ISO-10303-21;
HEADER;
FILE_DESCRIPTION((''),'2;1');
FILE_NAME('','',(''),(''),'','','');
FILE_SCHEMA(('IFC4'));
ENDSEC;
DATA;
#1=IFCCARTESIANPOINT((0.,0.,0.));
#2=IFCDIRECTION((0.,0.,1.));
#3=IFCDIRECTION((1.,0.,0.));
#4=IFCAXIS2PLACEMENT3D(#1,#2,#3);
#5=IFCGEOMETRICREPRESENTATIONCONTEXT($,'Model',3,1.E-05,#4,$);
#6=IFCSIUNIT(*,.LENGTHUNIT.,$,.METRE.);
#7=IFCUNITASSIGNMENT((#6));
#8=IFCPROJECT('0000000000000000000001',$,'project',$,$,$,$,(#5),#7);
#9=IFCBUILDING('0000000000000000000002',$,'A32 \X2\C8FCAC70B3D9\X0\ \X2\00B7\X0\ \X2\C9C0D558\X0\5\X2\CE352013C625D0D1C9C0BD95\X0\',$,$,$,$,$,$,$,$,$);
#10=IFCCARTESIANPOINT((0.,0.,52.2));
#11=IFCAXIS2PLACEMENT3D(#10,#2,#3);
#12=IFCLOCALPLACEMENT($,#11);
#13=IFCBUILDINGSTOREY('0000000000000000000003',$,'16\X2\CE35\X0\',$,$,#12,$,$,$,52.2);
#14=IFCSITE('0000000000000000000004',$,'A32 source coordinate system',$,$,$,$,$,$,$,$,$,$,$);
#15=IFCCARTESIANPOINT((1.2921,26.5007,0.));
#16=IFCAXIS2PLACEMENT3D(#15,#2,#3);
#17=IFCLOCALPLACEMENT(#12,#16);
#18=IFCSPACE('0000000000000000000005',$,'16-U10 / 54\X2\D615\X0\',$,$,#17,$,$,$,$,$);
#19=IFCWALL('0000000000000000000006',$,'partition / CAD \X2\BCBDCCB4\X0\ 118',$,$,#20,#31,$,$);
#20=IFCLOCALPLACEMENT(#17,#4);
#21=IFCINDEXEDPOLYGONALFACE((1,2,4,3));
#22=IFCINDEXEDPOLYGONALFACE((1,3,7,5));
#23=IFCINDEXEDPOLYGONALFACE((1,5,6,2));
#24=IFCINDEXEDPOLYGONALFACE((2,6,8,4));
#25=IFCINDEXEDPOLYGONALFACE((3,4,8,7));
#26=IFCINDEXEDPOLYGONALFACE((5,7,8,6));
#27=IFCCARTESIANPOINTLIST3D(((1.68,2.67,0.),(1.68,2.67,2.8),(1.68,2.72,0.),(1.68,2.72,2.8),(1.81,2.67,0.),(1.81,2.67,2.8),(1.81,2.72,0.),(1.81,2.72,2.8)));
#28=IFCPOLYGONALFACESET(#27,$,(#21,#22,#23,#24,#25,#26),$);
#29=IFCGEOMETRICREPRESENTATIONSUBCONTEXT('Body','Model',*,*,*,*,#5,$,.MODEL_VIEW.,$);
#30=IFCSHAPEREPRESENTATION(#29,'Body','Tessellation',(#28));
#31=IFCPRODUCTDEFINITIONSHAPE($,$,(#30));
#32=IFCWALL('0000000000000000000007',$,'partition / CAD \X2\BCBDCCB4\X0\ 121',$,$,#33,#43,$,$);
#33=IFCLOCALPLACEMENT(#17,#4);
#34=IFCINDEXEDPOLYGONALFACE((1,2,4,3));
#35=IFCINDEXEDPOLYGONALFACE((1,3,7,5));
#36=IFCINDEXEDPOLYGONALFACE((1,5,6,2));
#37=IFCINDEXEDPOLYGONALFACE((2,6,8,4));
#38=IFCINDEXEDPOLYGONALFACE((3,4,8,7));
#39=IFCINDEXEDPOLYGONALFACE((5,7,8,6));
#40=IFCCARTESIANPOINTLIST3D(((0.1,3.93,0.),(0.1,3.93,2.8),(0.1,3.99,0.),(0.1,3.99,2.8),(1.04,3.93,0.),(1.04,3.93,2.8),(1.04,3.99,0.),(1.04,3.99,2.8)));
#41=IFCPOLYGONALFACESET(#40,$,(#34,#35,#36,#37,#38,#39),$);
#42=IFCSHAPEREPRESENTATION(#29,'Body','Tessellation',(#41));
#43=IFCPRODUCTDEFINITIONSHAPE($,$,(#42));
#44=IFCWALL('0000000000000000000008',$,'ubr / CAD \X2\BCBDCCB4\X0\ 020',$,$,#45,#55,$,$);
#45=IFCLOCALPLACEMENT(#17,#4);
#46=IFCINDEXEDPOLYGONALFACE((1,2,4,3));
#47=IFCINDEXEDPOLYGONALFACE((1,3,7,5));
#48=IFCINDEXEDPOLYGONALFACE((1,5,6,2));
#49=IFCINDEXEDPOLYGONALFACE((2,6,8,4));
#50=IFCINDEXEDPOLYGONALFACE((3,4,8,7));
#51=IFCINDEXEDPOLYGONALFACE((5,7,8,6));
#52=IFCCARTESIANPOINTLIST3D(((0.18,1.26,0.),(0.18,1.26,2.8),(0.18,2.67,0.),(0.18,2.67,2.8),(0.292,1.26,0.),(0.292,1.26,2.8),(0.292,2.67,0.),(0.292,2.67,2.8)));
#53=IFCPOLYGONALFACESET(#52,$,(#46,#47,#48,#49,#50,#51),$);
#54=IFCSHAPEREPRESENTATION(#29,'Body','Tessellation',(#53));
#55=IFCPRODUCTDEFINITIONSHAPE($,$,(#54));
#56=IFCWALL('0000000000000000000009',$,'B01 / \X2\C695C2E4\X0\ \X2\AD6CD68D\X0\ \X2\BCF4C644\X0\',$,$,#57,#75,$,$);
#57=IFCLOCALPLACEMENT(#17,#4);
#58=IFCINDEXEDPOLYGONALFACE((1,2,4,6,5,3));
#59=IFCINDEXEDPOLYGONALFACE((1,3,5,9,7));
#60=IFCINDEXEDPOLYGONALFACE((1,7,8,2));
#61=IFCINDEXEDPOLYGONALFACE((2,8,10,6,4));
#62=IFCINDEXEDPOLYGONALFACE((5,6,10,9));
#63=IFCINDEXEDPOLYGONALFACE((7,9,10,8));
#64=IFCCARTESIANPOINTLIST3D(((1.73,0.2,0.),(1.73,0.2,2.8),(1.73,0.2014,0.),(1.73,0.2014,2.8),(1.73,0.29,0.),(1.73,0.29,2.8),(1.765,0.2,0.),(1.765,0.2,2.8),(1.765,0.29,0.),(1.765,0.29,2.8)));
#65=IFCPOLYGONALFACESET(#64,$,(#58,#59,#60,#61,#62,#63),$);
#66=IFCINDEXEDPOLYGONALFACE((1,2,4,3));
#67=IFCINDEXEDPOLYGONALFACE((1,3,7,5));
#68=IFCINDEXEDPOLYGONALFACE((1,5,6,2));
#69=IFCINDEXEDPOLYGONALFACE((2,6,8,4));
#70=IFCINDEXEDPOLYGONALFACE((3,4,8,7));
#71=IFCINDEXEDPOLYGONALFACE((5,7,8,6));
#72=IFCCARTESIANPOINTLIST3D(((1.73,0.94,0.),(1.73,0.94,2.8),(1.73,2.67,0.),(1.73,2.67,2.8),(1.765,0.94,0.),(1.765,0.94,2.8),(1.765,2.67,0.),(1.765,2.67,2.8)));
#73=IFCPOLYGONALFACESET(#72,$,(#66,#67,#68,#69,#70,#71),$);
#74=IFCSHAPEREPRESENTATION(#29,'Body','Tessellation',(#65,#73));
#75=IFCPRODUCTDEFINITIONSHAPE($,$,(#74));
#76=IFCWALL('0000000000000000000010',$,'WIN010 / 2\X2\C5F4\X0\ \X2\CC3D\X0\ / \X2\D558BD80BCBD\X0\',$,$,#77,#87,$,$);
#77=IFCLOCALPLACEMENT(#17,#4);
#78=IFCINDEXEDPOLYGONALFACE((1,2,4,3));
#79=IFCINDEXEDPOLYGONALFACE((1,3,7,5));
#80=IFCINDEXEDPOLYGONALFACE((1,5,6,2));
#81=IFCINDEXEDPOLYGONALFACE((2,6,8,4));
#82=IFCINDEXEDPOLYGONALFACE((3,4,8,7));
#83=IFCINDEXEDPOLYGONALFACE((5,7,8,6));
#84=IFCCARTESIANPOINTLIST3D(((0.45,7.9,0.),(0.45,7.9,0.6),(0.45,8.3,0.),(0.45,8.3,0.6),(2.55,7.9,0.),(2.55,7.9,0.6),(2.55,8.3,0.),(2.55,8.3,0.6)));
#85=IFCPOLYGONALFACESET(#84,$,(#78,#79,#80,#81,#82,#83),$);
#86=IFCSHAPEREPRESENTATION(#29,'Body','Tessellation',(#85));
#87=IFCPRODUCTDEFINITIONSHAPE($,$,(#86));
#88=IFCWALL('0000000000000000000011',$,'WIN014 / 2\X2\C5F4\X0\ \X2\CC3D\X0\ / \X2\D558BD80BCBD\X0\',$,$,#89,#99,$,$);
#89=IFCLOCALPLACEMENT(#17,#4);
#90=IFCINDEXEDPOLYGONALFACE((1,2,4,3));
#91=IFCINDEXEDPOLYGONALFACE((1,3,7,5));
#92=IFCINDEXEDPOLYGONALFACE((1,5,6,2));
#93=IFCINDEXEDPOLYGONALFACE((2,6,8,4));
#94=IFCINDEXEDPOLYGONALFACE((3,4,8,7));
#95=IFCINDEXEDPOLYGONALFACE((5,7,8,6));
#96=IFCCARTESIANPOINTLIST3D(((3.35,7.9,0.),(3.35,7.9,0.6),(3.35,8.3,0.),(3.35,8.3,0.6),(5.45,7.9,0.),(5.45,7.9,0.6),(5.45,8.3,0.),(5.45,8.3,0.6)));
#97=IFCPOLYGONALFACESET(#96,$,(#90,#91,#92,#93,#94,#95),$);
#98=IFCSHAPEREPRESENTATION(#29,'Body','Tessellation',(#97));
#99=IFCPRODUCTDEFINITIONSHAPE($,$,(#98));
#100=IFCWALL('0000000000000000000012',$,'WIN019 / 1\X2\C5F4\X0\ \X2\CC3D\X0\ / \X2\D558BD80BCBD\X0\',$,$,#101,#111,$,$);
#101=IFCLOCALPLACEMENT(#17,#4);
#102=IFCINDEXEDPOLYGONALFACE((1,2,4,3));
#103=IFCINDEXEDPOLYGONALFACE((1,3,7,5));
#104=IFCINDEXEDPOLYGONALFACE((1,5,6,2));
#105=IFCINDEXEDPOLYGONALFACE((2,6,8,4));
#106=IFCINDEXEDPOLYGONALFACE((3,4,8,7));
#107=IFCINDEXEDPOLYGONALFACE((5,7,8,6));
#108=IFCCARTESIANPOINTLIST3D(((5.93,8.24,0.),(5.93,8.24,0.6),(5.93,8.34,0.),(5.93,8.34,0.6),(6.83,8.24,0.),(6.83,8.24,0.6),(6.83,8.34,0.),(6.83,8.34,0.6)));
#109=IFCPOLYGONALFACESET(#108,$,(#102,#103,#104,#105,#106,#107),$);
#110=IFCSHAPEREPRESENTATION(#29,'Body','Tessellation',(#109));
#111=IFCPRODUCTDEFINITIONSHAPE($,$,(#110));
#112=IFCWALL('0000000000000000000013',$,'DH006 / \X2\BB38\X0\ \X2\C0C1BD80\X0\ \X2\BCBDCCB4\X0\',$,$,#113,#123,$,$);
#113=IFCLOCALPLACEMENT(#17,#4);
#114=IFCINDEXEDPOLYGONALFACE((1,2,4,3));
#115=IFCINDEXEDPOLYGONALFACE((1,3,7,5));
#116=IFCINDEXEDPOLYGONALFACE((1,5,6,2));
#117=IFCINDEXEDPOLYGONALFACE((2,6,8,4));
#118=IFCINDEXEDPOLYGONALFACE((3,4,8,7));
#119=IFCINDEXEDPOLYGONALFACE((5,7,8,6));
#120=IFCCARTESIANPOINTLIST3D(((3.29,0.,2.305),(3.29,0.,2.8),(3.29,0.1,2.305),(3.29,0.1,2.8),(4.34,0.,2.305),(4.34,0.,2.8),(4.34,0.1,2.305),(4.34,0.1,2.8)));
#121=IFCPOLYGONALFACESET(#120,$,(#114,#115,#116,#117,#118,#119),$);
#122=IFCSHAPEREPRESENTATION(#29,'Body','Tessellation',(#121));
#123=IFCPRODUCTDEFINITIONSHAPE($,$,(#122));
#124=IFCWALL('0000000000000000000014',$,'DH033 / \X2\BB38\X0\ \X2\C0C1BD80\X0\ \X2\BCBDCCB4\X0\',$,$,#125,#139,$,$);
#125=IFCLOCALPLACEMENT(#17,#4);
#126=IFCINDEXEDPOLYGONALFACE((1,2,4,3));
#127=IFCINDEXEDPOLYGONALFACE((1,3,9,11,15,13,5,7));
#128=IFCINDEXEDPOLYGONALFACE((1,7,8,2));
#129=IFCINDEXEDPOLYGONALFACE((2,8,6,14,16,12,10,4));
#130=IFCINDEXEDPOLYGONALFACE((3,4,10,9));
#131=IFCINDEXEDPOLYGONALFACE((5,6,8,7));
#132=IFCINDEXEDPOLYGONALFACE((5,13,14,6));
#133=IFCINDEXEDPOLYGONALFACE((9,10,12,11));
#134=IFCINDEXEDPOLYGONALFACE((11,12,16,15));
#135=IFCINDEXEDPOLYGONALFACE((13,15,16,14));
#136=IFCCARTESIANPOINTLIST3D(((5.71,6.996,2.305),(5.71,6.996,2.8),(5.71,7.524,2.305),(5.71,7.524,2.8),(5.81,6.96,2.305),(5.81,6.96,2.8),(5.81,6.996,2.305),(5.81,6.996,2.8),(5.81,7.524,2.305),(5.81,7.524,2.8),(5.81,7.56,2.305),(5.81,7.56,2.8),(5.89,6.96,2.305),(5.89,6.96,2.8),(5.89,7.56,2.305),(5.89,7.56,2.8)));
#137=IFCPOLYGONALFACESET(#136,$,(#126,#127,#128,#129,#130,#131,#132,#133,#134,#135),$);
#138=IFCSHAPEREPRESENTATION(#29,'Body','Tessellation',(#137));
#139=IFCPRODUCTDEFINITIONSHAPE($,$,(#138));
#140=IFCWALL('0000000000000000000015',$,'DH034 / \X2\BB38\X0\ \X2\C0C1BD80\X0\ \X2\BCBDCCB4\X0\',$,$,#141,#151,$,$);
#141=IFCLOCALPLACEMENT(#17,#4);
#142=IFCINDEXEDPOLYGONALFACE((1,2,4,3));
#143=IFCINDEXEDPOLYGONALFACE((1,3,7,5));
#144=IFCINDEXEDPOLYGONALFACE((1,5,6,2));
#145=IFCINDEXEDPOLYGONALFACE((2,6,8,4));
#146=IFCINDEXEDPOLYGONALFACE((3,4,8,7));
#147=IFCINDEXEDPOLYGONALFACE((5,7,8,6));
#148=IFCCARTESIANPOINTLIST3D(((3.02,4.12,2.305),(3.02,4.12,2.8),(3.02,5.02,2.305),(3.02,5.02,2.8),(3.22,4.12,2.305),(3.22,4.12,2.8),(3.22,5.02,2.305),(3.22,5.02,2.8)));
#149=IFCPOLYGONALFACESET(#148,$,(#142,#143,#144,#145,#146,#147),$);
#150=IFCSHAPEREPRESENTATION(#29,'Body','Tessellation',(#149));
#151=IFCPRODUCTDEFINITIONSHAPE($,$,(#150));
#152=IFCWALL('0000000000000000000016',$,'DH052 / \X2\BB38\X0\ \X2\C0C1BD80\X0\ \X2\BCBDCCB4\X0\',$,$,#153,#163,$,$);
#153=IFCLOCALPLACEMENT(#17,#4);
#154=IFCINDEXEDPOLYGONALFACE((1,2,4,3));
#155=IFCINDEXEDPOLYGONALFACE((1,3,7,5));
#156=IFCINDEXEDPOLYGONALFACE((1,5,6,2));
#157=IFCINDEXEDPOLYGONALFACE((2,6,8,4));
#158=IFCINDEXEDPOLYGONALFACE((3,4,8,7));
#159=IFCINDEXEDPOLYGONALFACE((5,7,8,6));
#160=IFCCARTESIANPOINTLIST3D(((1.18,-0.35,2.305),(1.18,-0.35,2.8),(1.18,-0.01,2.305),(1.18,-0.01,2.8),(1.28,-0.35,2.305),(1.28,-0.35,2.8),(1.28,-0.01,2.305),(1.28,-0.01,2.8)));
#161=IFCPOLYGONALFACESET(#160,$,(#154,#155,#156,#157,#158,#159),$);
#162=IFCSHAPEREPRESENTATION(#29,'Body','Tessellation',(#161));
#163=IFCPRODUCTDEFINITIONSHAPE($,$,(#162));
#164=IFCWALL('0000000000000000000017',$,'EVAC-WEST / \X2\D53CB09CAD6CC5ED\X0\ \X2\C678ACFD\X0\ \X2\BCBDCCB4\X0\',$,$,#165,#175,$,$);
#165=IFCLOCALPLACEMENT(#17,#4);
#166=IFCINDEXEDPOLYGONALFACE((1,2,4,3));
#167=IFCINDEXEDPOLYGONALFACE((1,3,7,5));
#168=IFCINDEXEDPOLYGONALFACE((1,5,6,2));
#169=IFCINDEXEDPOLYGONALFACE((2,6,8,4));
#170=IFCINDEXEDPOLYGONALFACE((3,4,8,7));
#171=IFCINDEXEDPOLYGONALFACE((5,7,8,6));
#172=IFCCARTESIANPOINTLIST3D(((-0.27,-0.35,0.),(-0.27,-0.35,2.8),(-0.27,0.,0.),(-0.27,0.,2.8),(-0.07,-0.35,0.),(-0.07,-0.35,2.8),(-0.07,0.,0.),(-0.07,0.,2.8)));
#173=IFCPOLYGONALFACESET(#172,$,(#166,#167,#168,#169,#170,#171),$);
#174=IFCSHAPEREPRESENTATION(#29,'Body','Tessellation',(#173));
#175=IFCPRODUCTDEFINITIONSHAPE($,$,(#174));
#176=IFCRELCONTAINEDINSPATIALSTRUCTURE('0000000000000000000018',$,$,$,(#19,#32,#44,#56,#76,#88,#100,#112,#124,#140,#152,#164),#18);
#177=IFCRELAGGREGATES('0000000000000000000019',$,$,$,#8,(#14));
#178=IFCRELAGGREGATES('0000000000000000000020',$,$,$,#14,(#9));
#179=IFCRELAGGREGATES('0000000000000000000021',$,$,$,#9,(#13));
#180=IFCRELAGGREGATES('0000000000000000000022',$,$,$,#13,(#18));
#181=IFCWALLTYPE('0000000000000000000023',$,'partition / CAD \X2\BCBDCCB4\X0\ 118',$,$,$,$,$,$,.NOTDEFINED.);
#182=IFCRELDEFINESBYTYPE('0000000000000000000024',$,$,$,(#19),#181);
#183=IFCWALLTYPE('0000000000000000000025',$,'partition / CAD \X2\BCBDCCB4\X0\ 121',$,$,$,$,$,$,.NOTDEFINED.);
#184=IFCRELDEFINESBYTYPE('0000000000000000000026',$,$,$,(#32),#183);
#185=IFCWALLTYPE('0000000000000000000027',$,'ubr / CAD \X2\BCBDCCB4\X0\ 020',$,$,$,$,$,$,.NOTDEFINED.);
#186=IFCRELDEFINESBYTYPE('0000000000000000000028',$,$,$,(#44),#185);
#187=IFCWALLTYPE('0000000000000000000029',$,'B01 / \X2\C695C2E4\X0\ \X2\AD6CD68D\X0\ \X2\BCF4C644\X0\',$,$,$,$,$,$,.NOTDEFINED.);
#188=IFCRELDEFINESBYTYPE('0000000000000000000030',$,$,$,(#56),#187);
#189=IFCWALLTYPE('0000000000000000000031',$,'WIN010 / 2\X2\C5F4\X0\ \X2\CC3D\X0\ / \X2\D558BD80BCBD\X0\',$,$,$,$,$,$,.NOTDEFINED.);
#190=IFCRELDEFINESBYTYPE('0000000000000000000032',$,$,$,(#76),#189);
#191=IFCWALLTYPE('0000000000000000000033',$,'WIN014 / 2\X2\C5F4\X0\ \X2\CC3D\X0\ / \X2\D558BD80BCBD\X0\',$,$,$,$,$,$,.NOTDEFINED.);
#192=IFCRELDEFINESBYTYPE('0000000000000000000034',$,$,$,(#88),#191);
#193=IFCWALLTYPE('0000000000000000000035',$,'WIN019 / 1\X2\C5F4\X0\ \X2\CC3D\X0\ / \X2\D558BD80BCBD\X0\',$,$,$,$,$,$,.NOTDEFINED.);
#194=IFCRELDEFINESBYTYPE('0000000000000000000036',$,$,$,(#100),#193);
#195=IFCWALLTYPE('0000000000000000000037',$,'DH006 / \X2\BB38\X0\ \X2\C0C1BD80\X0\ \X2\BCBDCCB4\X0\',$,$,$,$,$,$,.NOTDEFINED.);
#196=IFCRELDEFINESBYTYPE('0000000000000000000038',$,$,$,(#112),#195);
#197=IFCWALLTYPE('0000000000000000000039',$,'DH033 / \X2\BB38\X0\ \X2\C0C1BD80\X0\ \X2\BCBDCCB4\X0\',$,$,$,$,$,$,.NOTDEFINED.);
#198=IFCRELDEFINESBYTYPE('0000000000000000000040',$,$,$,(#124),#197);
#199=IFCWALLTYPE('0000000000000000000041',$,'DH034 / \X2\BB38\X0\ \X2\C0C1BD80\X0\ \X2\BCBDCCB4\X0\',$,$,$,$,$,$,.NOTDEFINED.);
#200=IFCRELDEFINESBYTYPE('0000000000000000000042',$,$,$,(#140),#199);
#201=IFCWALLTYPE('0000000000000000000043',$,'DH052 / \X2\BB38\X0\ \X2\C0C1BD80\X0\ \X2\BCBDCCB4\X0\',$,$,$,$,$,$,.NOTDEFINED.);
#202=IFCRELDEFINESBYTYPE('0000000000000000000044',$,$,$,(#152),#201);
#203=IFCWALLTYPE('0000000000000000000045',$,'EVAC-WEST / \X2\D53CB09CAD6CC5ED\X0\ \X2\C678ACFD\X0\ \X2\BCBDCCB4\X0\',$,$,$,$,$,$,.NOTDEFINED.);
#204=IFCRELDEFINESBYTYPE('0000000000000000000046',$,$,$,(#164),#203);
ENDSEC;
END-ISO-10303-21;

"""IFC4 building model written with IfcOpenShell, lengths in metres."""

from ifc_helpers import new_model, si_unit, frame, origin, origin_with_axes, place, context, subcontext, project, spatial, polyline, outline, extrude, source, transform, mapped, type_object, type_shapes, element, save


model = new_model("IFC4")

# Units and contexts
model_context = context("Model", 3, precision=1e-05, world=origin_with_axes())
body_context = subcontext(model_context, "Body", "Model", "MODEL_VIEW")
ifc_project = project(units=[si_unit("LENGTHUNIT", "METRE")], contexts=[model_context])

# Site, building, storey, space
site = spatial("IfcSite", under=ifc_project, Name="A32 source coordinate system")
building = spatial("IfcBuilding", under=site, Name="A32 주거동 · 지하5층–옥탑지붕")
storey_placement = place(None, frame((0.0, 0.0, 52.2), z_axis=(0.0, 0.0, 1.0), x_axis=(1.0, 0.0, 0.0)))
storey = spatial("IfcBuildingStorey", under=building, at=storey_placement, Name="16층", Elevation=52.2)
space_placement = place(storey_placement, frame((1.2921, 26.5007, 0.0), z_axis=(0.0, 0.0, 1.0), x_axis=(1.0, 0.0, 0.0)))
space = spatial("IfcSpace", under=storey, at=space_placement, Name="16-U10 / 54형")

# Walls
wall_type_1 = type_object("IfcWallType", Name="partition / CAD 벽체 118", PredefinedType="NOTDEFINED")
shared_shape_1 = source(origin(), body_context, "Body", "SweptSolid", [
    extrude(outline(polyline([(1.81, 2.67), (1.68, 2.67), (1.68, 2.72), (1.81, 2.72), (1.81, 2.67)])), origin(), (0.0, 0.0, 1.0), 2.8),
])
type_shapes(wall_type_1, [shared_shape_1])
wall_1_placement = place(space_placement, origin_with_axes())
element("IfcWall", 1, at=wall_1_placement, inside=space, type_object=wall_type_1, Name="partition / CAD 벽체 118", context=body_context, shape_type="MappedRepresentation", body=[
    mapped(shared_shape_1, transform((0.0, 0.0, 0.0), scale=1.0)),
])
wall_type_2 = type_object("IfcWallType", Name="partition / CAD 벽체 121", PredefinedType="NOTDEFINED")
shared_shape_2 = source(origin(), body_context, "Body", "SweptSolid", [
    extrude(outline(polyline([(0.1, 3.99), (1.04, 3.99), (1.04, 3.93), (0.1, 3.93), (0.1, 3.99)])), origin(), (0.0, 0.0, 1.0), 2.8),
])
type_shapes(wall_type_2, [shared_shape_2])
wall_2_placement = place(space_placement, origin_with_axes())
element("IfcWall", 2, at=wall_2_placement, inside=space, type_object=wall_type_2, Name="partition / CAD 벽체 121", context=body_context, shape_type="MappedRepresentation", body=[
    mapped(shared_shape_2, transform((0.0, 0.0, 0.0), scale=1.0)),
])
wall_type_3 = type_object("IfcWallType", Name="ubr / CAD 벽체 020", PredefinedType="NOTDEFINED")
shared_shape_3 = source(origin(), body_context, "Body", "SweptSolid", [
    extrude(outline(polyline([(0.18, 1.26), (0.18, 2.67), (0.292, 2.67), (0.292, 1.26), (0.18, 1.26)])), origin(), (0.0, 0.0, 1.0), 2.8),
])
type_shapes(wall_type_3, [shared_shape_3])
wall_3_placement = place(space_placement, origin_with_axes())
element("IfcWall", 3, at=wall_3_placement, inside=space, type_object=wall_type_3, Name="ubr / CAD 벽체 020", context=body_context, shape_type="MappedRepresentation", body=[
    mapped(shared_shape_3, transform((0.0, 0.0, 0.0), scale=1.0)),
])
wall_type_4 = type_object("IfcWallType", Name="B01 / 욕실 구획 보완", PredefinedType="NOTDEFINED")
shared_shape_4 = source(origin(), body_context, "Body", "SweptSolid", [
    extrude(outline(polyline([(1.765, 0.2), (1.73, 0.2), (1.73, 0.2014), (1.73, 0.29), (1.765, 0.29), (1.765, 0.2)])), origin(), (0.0, 0.0, 1.0), 2.8),
    extrude(outline(polyline([(1.765, 2.67), (1.765, 0.94), (1.73, 0.94), (1.73, 2.67), (1.765, 2.67)])), origin(), (0.0, 0.0, 1.0), 2.8),
])
type_shapes(wall_type_4, [shared_shape_4])
wall_4_placement = place(space_placement, origin_with_axes())
element("IfcWall", 4, at=wall_4_placement, inside=space, type_object=wall_type_4, Name="B01 / 욕실 구획 보완", context=body_context, shape_type="MappedRepresentation", body=[
    mapped(shared_shape_4, transform((0.0, 0.0, 0.0), scale=1.0)),
])
wall_type_5 = type_object("IfcWallType", Name="WIN010 / 2열 창 / 하부벽", PredefinedType="NOTDEFINED")
shared_shape_5 = source(origin(), body_context, "Body", "SweptSolid", [
    extrude(outline(polyline([(2.55, 8.3), (2.55, 7.9), (0.45, 7.9), (0.45, 8.3), (2.55, 8.3)])), origin(), (0.0, 0.0, 1.0), 0.6),
])
type_shapes(wall_type_5, [shared_shape_5])
wall_5_placement = place(space_placement, origin_with_axes())
element("IfcWall", 5, at=wall_5_placement, inside=space, type_object=wall_type_5, Name="WIN010 / 2열 창 / 하부벽", context=body_context, shape_type="MappedRepresentation", body=[
    mapped(shared_shape_5, transform((0.0, 0.0, 0.0), scale=1.0)),
])
wall_type_6 = type_object("IfcWallType", Name="WIN014 / 2열 창 / 하부벽", PredefinedType="NOTDEFINED")
shared_shape_6 = source(origin(), body_context, "Body", "SweptSolid", [
    extrude(outline(polyline([(5.45, 8.3), (5.45, 7.9), (3.35, 7.9), (3.35, 8.3), (5.45, 8.3)])), origin(), (0.0, 0.0, 1.0), 0.6),
])
type_shapes(wall_type_6, [shared_shape_6])
wall_6_placement = place(space_placement, origin_with_axes())
element("IfcWall", 6, at=wall_6_placement, inside=space, type_object=wall_type_6, Name="WIN014 / 2열 창 / 하부벽", context=body_context, shape_type="MappedRepresentation", body=[
    mapped(shared_shape_6, transform((0.0, 0.0, 0.0), scale=1.0)),
])
wall_type_7 = type_object("IfcWallType", Name="WIN019 / 1열 창 / 하부벽", PredefinedType="NOTDEFINED")
shared_shape_7 = source(origin(), body_context, "Body", "SweptSolid", [
    extrude(outline(polyline([(6.83, 8.34), (6.83, 8.24), (5.93, 8.24), (5.93, 8.34), (6.83, 8.34)])), origin(), (0.0, 0.0, 1.0), 0.6),
])
type_shapes(wall_type_7, [shared_shape_7])
wall_7_placement = place(space_placement, origin_with_axes())
element("IfcWall", 7, at=wall_7_placement, inside=space, type_object=wall_type_7, Name="WIN019 / 1열 창 / 하부벽", context=body_context, shape_type="MappedRepresentation", body=[
    mapped(shared_shape_7, transform((0.0, 0.0, 0.0), scale=1.0)),
])
wall_type_8 = type_object("IfcWallType", Name="DH006 / 문 상부 벽체", PredefinedType="NOTDEFINED")
shared_shape_8 = source(origin(), body_context, "Body", "SweptSolid", [
    extrude(outline(polyline([(4.34, 0.0), (3.29, 0.0), (3.29, 0.1), (4.34, 0.1), (4.34, 0.0)])), frame((0.0, 0.0, 2.305)), (0.0, 0.0, 1.0), 0.495),
])
type_shapes(wall_type_8, [shared_shape_8])
wall_8_placement = place(space_placement, origin_with_axes())
element("IfcWall", 8, at=wall_8_placement, inside=space, type_object=wall_type_8, Name="DH006 / 문 상부 벽체", context=body_context, shape_type="MappedRepresentation", body=[
    mapped(shared_shape_8, transform((0.0, 0.0, 0.0), scale=1.0)),
])
wall_type_9 = type_object("IfcWallType", Name="DH033 / 문 상부 벽체", PredefinedType="NOTDEFINED")
shared_shape_9 = source(origin(), body_context, "Body", "SweptSolid", [
    extrude(outline(polyline([(5.81, 6.996), (5.71, 6.996), (5.71, 7.524), (5.81, 7.524), (5.81, 7.56), (5.89, 7.56), (5.89, 6.96), (5.81, 6.96), (5.81, 6.996)])), frame((0.0, 0.0, 2.305)), (0.0, 0.0, 1.0), 0.495),
])
type_shapes(wall_type_9, [shared_shape_9])
wall_9_placement = place(space_placement, origin_with_axes())
element("IfcWall", 9, at=wall_9_placement, inside=space, type_object=wall_type_9, Name="DH033 / 문 상부 벽체", context=body_context, shape_type="MappedRepresentation", body=[
    mapped(shared_shape_9, transform((0.0, 0.0, 0.0), scale=1.0)),
])
wall_type_10 = type_object("IfcWallType", Name="DH034 / 문 상부 벽체", PredefinedType="NOTDEFINED")
shared_shape_10 = source(origin(), body_context, "Body", "SweptSolid", [
    extrude(outline(polyline([(3.22, 4.12), (3.02, 4.12), (3.02, 5.02), (3.22, 5.02), (3.22, 4.12)])), frame((0.0, 0.0, 2.305)), (0.0, 0.0, 1.0), 0.495),
])
type_shapes(wall_type_10, [shared_shape_10])
wall_10_placement = place(space_placement, origin_with_axes())
element("IfcWall", 10, at=wall_10_placement, inside=space, type_object=wall_type_10, Name="DH034 / 문 상부 벽체", context=body_context, shape_type="MappedRepresentation", body=[
    mapped(shared_shape_10, transform((0.0, 0.0, 0.0), scale=1.0)),
])
wall_type_11 = type_object("IfcWallType", Name="DH052 / 문 상부 벽체", PredefinedType="NOTDEFINED")
shared_shape_11 = source(origin(), body_context, "Body", "SweptSolid", [
    extrude(outline(polyline([(1.28, -0.35), (1.18, -0.35), (1.18, -0.01), (1.28, -0.01), (1.28, -0.35)])), frame((0.0, 0.0, 2.305)), (0.0, 0.0, 1.0), 0.495),
])
type_shapes(wall_type_11, [shared_shape_11])
wall_11_placement = place(space_placement, origin_with_axes())
element("IfcWall", 11, at=wall_11_placement, inside=space, type_object=wall_type_11, Name="DH052 / 문 상부 벽체", context=body_context, shape_type="MappedRepresentation", body=[
    mapped(shared_shape_11, transform((0.0, 0.0, 0.0), scale=1.0)),
])
wall_type_12 = type_object("IfcWallType", Name="EVAC-WEST / 피난구역 외곽 벽체", PredefinedType="NOTDEFINED")
shared_shape_12 = source(origin(), body_context, "Body", "SweptSolid", [
    extrude(outline(polyline([(-0.07, 0.0), (-0.07, -0.35), (-0.27, -0.35), (-0.27, 0.0), (-0.07, 0.0)])), origin(), (0.0, 0.0, 1.0), 2.8),
])
type_shapes(wall_type_12, [shared_shape_12])
wall_12_placement = place(space_placement, origin_with_axes())
element("IfcWall", 12, at=wall_12_placement, inside=space, type_object=wall_type_12, Name="EVAC-WEST / 피난구역 외곽 벽체", context=body_context, shape_type="MappedRepresentation", body=[
    mapped(shared_shape_12, transform((0.0, 0.0, 0.0), scale=1.0)),
])

save(model, "model.ifc")
